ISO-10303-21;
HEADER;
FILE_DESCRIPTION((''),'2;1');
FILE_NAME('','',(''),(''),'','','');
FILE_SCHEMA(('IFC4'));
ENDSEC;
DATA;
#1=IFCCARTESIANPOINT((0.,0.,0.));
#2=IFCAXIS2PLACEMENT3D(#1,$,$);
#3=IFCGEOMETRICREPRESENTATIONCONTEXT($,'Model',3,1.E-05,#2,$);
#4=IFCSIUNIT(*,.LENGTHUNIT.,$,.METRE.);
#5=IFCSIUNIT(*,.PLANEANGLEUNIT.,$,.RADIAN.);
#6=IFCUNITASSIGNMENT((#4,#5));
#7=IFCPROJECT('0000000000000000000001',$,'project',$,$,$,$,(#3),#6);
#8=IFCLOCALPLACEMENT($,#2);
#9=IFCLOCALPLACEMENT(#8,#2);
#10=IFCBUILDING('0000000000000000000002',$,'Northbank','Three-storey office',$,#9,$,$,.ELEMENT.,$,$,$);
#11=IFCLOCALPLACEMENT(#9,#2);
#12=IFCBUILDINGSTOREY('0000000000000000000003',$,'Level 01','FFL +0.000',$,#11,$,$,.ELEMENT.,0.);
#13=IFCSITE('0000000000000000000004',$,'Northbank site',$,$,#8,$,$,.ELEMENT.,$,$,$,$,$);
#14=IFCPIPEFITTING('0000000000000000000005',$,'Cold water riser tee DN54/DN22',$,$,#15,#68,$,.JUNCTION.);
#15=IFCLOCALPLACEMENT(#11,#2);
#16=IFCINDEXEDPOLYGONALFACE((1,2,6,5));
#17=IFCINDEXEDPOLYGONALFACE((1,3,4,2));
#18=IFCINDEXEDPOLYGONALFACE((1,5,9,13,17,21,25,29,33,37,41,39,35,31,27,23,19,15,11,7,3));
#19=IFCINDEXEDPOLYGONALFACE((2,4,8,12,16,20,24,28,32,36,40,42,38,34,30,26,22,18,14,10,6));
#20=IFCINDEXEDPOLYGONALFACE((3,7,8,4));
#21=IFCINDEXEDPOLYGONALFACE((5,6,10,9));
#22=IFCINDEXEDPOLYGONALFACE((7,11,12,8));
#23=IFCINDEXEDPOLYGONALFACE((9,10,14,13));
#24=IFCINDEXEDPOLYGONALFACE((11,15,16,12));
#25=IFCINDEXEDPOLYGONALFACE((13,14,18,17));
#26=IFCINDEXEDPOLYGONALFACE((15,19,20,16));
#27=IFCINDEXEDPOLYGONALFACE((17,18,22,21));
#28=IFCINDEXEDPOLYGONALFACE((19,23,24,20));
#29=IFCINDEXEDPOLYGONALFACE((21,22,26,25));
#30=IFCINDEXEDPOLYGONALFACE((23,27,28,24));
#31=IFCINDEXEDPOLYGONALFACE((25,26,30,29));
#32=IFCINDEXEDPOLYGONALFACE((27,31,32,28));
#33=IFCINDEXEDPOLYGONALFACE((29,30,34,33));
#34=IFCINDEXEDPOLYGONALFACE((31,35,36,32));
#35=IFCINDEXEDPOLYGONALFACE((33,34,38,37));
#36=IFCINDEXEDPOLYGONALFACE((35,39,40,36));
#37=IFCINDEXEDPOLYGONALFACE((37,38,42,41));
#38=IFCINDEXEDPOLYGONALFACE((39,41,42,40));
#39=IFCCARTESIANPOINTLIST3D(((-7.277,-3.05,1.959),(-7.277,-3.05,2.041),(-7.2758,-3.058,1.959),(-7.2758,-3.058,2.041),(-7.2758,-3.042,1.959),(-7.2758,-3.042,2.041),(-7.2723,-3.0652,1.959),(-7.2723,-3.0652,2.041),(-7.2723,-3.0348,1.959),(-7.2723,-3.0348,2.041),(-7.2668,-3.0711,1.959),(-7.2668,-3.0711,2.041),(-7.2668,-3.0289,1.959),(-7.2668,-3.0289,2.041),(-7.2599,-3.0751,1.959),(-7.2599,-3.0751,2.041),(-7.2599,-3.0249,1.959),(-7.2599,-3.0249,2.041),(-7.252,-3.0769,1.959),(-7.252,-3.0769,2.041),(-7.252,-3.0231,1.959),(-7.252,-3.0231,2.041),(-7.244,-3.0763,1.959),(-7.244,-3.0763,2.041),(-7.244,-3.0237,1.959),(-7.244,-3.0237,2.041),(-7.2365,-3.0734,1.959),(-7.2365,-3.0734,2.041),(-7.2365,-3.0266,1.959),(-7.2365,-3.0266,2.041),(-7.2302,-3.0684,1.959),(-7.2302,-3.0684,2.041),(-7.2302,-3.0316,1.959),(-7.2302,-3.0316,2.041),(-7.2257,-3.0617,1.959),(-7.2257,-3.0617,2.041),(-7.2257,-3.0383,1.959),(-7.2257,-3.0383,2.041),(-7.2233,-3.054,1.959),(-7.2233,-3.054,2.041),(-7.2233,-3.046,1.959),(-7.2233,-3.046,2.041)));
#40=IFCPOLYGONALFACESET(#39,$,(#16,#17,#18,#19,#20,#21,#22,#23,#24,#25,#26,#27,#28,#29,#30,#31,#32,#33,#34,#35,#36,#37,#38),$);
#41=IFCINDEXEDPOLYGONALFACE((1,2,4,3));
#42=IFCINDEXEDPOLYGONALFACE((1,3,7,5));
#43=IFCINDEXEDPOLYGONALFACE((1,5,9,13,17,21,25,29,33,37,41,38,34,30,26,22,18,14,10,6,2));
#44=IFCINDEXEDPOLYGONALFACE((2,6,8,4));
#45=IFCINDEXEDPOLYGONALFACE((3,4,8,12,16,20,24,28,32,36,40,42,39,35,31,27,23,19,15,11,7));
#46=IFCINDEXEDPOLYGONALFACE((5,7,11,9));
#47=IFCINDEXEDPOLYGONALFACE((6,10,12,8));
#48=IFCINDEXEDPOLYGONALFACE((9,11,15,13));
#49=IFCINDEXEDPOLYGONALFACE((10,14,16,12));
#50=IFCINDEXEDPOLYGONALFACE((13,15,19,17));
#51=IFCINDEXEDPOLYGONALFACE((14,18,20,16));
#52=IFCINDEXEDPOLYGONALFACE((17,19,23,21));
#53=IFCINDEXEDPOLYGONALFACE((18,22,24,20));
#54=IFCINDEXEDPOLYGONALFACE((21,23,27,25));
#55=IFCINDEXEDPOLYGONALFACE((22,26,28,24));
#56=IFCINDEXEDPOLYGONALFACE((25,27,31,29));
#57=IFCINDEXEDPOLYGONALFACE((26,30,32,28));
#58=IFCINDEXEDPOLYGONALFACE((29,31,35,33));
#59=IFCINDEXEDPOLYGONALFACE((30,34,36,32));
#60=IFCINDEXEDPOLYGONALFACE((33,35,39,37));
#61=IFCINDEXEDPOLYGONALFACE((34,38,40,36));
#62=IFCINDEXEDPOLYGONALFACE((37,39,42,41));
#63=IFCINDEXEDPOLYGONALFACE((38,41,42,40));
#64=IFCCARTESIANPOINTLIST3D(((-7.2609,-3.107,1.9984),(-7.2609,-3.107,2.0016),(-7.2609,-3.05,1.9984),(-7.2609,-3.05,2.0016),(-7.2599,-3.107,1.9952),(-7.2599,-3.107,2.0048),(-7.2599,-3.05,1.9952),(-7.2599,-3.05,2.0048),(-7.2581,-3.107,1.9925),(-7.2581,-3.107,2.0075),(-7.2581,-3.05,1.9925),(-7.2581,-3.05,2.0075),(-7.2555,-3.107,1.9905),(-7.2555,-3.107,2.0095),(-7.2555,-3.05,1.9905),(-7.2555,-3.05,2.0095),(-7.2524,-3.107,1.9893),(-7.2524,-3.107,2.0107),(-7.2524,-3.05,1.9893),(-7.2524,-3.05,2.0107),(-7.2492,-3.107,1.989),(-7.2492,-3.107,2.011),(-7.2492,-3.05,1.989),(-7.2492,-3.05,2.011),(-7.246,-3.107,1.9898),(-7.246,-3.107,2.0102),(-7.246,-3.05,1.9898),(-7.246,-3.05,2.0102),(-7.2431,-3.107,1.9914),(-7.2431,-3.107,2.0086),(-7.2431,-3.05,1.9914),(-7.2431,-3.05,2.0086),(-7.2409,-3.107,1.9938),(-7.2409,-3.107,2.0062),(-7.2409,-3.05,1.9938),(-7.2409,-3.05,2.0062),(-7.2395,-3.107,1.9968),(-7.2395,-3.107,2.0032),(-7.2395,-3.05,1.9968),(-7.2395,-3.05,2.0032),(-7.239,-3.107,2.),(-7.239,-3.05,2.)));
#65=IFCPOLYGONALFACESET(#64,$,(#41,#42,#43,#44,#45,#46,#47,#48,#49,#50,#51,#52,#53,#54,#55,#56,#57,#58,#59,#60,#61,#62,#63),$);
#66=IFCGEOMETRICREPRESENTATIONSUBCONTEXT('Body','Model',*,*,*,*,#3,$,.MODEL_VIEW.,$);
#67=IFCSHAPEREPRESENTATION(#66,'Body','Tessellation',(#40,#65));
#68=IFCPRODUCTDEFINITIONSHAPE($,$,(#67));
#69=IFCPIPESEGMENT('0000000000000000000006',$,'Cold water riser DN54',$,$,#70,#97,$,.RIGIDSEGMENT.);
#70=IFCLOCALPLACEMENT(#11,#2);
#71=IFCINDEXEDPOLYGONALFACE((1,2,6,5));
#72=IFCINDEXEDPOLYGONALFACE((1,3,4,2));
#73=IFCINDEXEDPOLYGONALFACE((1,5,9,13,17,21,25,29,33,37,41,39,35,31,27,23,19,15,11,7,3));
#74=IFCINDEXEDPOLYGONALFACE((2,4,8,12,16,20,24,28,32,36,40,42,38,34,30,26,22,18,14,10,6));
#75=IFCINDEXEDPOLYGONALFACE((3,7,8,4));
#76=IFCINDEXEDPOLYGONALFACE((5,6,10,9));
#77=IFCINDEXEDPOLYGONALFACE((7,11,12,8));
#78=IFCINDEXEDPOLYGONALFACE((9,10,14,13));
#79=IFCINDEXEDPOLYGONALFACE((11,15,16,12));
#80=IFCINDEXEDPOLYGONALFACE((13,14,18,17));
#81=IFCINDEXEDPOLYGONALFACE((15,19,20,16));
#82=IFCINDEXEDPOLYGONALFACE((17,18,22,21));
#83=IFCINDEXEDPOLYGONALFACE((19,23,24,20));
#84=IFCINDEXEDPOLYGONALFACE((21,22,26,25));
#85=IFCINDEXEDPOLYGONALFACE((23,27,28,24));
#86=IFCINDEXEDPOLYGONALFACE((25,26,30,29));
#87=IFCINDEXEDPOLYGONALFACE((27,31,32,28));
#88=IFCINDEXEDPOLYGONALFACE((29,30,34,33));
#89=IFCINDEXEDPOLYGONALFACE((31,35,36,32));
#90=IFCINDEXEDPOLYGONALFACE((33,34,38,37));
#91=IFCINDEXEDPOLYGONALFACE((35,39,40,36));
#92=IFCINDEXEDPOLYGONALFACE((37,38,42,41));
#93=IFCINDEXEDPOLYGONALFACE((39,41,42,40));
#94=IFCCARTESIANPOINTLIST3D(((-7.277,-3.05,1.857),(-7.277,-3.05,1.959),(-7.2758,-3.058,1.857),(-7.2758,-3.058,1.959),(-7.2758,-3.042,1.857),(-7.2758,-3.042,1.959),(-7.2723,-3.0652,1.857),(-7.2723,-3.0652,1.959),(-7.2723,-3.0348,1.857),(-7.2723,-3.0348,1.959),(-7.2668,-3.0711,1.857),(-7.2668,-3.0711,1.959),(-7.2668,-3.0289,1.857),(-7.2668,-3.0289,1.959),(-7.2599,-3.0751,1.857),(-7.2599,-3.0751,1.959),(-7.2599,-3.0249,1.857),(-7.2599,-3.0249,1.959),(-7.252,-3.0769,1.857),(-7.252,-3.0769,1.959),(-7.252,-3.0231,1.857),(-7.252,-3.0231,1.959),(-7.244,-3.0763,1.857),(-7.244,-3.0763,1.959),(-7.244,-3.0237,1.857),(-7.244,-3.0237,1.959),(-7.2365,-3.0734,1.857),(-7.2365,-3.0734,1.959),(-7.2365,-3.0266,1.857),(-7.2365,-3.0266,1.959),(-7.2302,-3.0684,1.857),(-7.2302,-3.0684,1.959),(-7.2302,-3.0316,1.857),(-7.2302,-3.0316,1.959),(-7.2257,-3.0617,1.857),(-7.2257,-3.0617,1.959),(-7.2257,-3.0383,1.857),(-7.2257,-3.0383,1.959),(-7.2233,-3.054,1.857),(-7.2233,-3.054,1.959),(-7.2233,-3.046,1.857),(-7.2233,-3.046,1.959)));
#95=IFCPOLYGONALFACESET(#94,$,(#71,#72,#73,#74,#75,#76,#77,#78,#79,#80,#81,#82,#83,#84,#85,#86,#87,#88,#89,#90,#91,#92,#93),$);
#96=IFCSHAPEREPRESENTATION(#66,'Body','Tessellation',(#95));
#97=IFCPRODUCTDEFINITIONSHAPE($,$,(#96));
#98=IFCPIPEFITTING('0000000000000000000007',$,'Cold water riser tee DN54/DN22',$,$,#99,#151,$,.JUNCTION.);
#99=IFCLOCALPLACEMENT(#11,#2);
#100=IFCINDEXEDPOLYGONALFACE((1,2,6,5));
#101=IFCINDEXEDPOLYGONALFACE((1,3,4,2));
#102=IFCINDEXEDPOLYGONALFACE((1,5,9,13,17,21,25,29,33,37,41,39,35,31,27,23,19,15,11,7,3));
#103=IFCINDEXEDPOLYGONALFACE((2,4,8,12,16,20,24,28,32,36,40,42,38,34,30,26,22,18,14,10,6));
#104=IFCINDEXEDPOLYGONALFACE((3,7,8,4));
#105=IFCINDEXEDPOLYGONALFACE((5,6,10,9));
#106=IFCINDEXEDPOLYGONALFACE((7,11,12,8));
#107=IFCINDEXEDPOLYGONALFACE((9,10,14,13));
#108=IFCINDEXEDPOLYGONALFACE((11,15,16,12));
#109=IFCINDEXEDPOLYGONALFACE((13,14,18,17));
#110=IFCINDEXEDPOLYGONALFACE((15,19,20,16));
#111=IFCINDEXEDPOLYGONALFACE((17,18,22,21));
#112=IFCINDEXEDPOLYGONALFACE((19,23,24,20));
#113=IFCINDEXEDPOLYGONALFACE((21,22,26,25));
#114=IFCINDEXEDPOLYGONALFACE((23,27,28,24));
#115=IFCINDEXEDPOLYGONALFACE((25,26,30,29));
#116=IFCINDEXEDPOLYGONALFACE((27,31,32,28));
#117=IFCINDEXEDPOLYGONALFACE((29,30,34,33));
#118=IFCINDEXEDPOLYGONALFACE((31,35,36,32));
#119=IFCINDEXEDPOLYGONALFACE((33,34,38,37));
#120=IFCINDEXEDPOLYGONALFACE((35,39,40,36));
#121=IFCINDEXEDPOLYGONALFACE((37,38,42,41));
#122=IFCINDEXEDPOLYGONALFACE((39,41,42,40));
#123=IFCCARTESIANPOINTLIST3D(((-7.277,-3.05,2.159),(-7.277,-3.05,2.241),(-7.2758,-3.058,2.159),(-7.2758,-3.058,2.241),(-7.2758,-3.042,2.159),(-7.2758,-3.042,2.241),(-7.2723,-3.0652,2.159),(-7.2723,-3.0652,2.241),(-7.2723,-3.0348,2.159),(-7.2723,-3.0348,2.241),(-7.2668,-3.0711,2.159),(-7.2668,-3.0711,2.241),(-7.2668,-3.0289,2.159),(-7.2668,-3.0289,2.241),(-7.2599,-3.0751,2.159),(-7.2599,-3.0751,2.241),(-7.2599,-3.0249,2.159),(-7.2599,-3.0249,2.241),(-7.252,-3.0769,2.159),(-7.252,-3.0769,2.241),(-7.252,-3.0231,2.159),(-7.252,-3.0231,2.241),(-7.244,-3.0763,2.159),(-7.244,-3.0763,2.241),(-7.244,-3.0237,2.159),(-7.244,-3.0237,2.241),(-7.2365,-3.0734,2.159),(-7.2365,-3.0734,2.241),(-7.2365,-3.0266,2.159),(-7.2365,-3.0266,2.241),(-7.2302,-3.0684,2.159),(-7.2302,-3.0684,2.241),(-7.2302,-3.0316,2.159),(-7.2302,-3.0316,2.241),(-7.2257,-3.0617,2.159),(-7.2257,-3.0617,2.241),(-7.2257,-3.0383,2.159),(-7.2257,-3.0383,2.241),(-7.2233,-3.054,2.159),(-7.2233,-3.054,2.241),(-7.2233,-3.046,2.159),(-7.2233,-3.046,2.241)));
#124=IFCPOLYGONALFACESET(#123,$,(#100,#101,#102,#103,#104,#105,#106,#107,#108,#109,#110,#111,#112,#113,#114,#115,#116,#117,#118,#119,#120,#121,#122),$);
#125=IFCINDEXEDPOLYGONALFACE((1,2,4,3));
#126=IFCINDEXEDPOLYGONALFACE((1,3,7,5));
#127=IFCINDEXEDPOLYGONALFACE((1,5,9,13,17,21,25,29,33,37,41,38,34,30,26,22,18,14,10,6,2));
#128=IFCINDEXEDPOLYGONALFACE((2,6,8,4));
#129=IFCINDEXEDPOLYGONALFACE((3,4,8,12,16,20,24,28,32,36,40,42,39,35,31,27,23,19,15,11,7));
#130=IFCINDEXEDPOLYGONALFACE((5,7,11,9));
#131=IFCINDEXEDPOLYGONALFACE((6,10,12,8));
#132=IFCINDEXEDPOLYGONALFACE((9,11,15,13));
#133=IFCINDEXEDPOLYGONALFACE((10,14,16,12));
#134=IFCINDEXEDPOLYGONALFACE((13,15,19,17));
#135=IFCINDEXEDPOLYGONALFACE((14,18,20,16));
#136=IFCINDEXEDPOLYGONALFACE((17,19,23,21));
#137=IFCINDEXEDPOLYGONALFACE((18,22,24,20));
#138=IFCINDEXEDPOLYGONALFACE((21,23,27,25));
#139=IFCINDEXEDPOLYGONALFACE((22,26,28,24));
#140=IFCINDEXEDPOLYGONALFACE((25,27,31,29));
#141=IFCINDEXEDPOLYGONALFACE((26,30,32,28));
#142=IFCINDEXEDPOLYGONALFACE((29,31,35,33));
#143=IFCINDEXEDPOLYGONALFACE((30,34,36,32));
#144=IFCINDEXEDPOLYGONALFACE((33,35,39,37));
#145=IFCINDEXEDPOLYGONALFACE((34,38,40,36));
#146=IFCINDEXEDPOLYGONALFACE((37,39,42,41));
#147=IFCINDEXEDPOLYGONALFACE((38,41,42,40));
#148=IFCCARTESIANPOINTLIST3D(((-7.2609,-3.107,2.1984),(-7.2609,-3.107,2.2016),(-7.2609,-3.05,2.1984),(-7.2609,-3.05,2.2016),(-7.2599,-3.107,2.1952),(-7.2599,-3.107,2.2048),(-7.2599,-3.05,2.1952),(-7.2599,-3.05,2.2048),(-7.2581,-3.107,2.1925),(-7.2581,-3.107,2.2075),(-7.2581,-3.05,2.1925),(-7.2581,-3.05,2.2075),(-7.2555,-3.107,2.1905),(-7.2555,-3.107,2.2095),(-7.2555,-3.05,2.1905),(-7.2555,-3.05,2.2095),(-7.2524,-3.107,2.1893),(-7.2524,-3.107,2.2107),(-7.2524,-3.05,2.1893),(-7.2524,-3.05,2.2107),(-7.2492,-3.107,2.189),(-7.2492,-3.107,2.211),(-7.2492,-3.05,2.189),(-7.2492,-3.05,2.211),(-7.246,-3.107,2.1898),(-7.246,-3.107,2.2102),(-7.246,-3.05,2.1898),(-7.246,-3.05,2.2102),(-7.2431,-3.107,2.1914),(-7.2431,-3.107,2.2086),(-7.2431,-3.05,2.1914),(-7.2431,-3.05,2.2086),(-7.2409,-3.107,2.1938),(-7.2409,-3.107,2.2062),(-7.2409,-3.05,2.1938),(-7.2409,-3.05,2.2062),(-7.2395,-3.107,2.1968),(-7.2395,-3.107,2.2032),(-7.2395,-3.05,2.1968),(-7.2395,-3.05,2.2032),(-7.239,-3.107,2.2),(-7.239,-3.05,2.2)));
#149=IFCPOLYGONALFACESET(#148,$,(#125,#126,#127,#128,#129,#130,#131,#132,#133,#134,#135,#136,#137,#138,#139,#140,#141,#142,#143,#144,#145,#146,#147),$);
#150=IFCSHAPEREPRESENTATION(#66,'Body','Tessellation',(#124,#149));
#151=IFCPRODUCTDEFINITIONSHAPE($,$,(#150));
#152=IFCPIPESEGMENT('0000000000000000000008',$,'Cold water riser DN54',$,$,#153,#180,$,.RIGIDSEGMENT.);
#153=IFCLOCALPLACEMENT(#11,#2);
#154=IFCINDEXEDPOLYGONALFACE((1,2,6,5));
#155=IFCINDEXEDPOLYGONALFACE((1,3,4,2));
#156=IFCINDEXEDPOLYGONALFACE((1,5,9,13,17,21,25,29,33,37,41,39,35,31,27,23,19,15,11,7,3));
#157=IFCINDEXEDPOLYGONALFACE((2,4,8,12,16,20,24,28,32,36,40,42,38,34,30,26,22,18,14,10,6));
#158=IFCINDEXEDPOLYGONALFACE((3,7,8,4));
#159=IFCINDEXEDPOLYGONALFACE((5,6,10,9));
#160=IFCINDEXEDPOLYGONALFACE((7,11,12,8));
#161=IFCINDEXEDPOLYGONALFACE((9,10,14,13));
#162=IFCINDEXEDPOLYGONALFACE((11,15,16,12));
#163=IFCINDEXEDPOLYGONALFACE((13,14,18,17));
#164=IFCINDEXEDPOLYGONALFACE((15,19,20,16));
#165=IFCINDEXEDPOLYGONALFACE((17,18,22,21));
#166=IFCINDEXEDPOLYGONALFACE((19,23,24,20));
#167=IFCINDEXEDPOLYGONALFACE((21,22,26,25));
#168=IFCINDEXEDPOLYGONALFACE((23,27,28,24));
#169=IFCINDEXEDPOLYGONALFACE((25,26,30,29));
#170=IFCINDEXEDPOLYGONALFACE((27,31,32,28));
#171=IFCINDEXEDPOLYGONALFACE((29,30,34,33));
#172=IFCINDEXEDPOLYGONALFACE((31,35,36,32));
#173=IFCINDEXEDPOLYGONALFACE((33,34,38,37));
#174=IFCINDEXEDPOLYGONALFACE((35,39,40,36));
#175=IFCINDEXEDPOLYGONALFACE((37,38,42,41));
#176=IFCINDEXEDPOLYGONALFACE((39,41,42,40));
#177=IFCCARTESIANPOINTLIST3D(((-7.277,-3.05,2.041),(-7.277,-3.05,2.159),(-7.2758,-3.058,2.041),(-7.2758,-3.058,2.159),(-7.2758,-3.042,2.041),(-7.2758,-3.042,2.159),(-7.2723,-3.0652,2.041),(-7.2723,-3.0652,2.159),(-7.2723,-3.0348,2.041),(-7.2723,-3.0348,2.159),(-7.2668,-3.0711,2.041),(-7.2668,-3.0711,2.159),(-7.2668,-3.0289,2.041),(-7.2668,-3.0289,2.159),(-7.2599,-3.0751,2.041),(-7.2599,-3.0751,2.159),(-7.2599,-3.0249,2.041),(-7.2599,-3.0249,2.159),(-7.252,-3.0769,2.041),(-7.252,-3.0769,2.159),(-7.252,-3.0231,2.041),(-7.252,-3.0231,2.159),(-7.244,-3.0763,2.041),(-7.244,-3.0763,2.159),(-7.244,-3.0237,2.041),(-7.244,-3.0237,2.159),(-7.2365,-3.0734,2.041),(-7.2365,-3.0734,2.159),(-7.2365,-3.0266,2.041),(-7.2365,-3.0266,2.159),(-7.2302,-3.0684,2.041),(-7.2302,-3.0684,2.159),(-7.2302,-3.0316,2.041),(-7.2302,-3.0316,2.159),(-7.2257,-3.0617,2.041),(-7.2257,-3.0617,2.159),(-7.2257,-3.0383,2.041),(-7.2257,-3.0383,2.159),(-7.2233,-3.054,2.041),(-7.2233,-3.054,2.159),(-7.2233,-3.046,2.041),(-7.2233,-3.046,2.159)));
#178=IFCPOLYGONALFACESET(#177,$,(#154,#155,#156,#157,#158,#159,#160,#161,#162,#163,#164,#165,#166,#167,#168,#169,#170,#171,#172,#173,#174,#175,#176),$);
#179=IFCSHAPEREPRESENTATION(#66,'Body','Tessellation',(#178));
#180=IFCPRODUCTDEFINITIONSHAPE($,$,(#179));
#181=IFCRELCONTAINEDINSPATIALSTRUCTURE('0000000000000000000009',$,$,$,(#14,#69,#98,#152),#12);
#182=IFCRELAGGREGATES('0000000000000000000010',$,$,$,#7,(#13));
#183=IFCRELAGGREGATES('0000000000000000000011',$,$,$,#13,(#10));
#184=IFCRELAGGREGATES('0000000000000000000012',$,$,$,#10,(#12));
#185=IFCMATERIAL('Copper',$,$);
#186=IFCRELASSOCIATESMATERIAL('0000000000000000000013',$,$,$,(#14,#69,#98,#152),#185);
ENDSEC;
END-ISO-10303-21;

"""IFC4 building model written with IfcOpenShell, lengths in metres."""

from ifc_helpers import new_model, si_unit, frame, origin, place, context, subcontext, project, spatial, circle, extrude, material, element, save


model = new_model("IFC4")

# Units and contexts
model_context = context("Model", 3, precision=1e-05, world=origin())
body_context = subcontext(model_context, "Body", "Model", "MODEL_VIEW")
ifc_project = project(units=[si_unit("LENGTHUNIT", "METRE"), si_unit("PLANEANGLEUNIT", "RADIAN")], contexts=[model_context])

# Site, building, storey
site_placement = place(None, origin())
site = spatial("IfcSite", under=ifc_project, at=site_placement, Name="Northbank site", CompositionType="ELEMENT")
building_placement = place(site_placement, origin())
building = spatial("IfcBuilding", under=site, at=building_placement, Name="Northbank", Description="Three-storey office", CompositionType="ELEMENT")
storey_placement = place(building_placement, origin())
storey = spatial("IfcBuildingStorey", under=building, at=storey_placement, Name="Level 01", Description="FFL +0.000", CompositionType="ELEMENT", Elevation=0.0)

# Pipe fitting
ifc_material = material(Name="Copper")
pipe_fitting_1_placement = place(storey_placement, origin())
element("IfcPipeFitting", 1, at=pipe_fitting_1_placement, inside=storey, material=ifc_material, Name="Cold water riser tee DN54/DN22", PredefinedType="JUNCTION", context=body_context, shape_type="SweptSolid", body=[
    extrude(circle(Radius=0.027), frame((-7.25, -3.05, 1.959), z_axis=(0.0, 0.0, 1.0), x_axis=(-1.0, 0.0, 0.0)), (0.0, 0.0, 1.0), 0.082),
    extrude(circle(Radius=0.011), frame((-7.25, -3.05, 2.0), z_axis=(0.0, -1.0, 0.0), x_axis=(1.0, 0.0, 0.0)), (0.0, 0.0, 1.0), 0.057),
])

# Pipe segment
pipe_segment_1_placement = place(storey_placement, origin())
element("IfcPipeSegment", 2, at=pipe_segment_1_placement, inside=storey, material=ifc_material, Name="Cold water riser DN54", PredefinedType="RIGIDSEGMENT", context=body_context, shape_type="SweptSolid", body=[
    extrude(circle(Radius=0.027), frame((-7.25, -3.05, 1.857), z_axis=(0.0, 0.0, 1.0), x_axis=(-1.0, 0.0, 0.0)), (0.0, 0.0, 1.0), 0.102),
])

# Pipe fitting
pipe_fitting_2_placement = place(storey_placement, origin())
element("IfcPipeFitting", 3, at=pipe_fitting_2_placement, inside=storey, material=ifc_material, Name="Cold water riser tee DN54/DN22", PredefinedType="JUNCTION", context=body_context, shape_type="SweptSolid", body=[
    extrude(circle(Radius=0.027), frame((-7.25, -3.05, 2.159), z_axis=(0.0, 0.0, 1.0), x_axis=(-1.0, 0.0, 0.0)), (0.0, 0.0, 1.0), 0.082),
    extrude(circle(Radius=0.011), frame((-7.25, -3.05, 2.2), z_axis=(0.0, -1.0, 0.0), x_axis=(1.0, 0.0, 0.0)), (0.0, 0.0, 1.0), 0.057),
])

# Pipe segment
pipe_segment_2_placement = place(storey_placement, origin())
element("IfcPipeSegment", 4, at=pipe_segment_2_placement, inside=storey, material=ifc_material, Name="Cold water riser DN54", PredefinedType="RIGIDSEGMENT", context=body_context, shape_type="SweptSolid", body=[
    extrude(circle(Radius=0.027), frame((-7.25, -3.05, 2.041), z_axis=(0.0, 0.0, 1.0), x_axis=(-1.0, 0.0, 0.0)), (0.0, 0.0, 1.0), 0.118),
])

save(model, "model.ifc")
